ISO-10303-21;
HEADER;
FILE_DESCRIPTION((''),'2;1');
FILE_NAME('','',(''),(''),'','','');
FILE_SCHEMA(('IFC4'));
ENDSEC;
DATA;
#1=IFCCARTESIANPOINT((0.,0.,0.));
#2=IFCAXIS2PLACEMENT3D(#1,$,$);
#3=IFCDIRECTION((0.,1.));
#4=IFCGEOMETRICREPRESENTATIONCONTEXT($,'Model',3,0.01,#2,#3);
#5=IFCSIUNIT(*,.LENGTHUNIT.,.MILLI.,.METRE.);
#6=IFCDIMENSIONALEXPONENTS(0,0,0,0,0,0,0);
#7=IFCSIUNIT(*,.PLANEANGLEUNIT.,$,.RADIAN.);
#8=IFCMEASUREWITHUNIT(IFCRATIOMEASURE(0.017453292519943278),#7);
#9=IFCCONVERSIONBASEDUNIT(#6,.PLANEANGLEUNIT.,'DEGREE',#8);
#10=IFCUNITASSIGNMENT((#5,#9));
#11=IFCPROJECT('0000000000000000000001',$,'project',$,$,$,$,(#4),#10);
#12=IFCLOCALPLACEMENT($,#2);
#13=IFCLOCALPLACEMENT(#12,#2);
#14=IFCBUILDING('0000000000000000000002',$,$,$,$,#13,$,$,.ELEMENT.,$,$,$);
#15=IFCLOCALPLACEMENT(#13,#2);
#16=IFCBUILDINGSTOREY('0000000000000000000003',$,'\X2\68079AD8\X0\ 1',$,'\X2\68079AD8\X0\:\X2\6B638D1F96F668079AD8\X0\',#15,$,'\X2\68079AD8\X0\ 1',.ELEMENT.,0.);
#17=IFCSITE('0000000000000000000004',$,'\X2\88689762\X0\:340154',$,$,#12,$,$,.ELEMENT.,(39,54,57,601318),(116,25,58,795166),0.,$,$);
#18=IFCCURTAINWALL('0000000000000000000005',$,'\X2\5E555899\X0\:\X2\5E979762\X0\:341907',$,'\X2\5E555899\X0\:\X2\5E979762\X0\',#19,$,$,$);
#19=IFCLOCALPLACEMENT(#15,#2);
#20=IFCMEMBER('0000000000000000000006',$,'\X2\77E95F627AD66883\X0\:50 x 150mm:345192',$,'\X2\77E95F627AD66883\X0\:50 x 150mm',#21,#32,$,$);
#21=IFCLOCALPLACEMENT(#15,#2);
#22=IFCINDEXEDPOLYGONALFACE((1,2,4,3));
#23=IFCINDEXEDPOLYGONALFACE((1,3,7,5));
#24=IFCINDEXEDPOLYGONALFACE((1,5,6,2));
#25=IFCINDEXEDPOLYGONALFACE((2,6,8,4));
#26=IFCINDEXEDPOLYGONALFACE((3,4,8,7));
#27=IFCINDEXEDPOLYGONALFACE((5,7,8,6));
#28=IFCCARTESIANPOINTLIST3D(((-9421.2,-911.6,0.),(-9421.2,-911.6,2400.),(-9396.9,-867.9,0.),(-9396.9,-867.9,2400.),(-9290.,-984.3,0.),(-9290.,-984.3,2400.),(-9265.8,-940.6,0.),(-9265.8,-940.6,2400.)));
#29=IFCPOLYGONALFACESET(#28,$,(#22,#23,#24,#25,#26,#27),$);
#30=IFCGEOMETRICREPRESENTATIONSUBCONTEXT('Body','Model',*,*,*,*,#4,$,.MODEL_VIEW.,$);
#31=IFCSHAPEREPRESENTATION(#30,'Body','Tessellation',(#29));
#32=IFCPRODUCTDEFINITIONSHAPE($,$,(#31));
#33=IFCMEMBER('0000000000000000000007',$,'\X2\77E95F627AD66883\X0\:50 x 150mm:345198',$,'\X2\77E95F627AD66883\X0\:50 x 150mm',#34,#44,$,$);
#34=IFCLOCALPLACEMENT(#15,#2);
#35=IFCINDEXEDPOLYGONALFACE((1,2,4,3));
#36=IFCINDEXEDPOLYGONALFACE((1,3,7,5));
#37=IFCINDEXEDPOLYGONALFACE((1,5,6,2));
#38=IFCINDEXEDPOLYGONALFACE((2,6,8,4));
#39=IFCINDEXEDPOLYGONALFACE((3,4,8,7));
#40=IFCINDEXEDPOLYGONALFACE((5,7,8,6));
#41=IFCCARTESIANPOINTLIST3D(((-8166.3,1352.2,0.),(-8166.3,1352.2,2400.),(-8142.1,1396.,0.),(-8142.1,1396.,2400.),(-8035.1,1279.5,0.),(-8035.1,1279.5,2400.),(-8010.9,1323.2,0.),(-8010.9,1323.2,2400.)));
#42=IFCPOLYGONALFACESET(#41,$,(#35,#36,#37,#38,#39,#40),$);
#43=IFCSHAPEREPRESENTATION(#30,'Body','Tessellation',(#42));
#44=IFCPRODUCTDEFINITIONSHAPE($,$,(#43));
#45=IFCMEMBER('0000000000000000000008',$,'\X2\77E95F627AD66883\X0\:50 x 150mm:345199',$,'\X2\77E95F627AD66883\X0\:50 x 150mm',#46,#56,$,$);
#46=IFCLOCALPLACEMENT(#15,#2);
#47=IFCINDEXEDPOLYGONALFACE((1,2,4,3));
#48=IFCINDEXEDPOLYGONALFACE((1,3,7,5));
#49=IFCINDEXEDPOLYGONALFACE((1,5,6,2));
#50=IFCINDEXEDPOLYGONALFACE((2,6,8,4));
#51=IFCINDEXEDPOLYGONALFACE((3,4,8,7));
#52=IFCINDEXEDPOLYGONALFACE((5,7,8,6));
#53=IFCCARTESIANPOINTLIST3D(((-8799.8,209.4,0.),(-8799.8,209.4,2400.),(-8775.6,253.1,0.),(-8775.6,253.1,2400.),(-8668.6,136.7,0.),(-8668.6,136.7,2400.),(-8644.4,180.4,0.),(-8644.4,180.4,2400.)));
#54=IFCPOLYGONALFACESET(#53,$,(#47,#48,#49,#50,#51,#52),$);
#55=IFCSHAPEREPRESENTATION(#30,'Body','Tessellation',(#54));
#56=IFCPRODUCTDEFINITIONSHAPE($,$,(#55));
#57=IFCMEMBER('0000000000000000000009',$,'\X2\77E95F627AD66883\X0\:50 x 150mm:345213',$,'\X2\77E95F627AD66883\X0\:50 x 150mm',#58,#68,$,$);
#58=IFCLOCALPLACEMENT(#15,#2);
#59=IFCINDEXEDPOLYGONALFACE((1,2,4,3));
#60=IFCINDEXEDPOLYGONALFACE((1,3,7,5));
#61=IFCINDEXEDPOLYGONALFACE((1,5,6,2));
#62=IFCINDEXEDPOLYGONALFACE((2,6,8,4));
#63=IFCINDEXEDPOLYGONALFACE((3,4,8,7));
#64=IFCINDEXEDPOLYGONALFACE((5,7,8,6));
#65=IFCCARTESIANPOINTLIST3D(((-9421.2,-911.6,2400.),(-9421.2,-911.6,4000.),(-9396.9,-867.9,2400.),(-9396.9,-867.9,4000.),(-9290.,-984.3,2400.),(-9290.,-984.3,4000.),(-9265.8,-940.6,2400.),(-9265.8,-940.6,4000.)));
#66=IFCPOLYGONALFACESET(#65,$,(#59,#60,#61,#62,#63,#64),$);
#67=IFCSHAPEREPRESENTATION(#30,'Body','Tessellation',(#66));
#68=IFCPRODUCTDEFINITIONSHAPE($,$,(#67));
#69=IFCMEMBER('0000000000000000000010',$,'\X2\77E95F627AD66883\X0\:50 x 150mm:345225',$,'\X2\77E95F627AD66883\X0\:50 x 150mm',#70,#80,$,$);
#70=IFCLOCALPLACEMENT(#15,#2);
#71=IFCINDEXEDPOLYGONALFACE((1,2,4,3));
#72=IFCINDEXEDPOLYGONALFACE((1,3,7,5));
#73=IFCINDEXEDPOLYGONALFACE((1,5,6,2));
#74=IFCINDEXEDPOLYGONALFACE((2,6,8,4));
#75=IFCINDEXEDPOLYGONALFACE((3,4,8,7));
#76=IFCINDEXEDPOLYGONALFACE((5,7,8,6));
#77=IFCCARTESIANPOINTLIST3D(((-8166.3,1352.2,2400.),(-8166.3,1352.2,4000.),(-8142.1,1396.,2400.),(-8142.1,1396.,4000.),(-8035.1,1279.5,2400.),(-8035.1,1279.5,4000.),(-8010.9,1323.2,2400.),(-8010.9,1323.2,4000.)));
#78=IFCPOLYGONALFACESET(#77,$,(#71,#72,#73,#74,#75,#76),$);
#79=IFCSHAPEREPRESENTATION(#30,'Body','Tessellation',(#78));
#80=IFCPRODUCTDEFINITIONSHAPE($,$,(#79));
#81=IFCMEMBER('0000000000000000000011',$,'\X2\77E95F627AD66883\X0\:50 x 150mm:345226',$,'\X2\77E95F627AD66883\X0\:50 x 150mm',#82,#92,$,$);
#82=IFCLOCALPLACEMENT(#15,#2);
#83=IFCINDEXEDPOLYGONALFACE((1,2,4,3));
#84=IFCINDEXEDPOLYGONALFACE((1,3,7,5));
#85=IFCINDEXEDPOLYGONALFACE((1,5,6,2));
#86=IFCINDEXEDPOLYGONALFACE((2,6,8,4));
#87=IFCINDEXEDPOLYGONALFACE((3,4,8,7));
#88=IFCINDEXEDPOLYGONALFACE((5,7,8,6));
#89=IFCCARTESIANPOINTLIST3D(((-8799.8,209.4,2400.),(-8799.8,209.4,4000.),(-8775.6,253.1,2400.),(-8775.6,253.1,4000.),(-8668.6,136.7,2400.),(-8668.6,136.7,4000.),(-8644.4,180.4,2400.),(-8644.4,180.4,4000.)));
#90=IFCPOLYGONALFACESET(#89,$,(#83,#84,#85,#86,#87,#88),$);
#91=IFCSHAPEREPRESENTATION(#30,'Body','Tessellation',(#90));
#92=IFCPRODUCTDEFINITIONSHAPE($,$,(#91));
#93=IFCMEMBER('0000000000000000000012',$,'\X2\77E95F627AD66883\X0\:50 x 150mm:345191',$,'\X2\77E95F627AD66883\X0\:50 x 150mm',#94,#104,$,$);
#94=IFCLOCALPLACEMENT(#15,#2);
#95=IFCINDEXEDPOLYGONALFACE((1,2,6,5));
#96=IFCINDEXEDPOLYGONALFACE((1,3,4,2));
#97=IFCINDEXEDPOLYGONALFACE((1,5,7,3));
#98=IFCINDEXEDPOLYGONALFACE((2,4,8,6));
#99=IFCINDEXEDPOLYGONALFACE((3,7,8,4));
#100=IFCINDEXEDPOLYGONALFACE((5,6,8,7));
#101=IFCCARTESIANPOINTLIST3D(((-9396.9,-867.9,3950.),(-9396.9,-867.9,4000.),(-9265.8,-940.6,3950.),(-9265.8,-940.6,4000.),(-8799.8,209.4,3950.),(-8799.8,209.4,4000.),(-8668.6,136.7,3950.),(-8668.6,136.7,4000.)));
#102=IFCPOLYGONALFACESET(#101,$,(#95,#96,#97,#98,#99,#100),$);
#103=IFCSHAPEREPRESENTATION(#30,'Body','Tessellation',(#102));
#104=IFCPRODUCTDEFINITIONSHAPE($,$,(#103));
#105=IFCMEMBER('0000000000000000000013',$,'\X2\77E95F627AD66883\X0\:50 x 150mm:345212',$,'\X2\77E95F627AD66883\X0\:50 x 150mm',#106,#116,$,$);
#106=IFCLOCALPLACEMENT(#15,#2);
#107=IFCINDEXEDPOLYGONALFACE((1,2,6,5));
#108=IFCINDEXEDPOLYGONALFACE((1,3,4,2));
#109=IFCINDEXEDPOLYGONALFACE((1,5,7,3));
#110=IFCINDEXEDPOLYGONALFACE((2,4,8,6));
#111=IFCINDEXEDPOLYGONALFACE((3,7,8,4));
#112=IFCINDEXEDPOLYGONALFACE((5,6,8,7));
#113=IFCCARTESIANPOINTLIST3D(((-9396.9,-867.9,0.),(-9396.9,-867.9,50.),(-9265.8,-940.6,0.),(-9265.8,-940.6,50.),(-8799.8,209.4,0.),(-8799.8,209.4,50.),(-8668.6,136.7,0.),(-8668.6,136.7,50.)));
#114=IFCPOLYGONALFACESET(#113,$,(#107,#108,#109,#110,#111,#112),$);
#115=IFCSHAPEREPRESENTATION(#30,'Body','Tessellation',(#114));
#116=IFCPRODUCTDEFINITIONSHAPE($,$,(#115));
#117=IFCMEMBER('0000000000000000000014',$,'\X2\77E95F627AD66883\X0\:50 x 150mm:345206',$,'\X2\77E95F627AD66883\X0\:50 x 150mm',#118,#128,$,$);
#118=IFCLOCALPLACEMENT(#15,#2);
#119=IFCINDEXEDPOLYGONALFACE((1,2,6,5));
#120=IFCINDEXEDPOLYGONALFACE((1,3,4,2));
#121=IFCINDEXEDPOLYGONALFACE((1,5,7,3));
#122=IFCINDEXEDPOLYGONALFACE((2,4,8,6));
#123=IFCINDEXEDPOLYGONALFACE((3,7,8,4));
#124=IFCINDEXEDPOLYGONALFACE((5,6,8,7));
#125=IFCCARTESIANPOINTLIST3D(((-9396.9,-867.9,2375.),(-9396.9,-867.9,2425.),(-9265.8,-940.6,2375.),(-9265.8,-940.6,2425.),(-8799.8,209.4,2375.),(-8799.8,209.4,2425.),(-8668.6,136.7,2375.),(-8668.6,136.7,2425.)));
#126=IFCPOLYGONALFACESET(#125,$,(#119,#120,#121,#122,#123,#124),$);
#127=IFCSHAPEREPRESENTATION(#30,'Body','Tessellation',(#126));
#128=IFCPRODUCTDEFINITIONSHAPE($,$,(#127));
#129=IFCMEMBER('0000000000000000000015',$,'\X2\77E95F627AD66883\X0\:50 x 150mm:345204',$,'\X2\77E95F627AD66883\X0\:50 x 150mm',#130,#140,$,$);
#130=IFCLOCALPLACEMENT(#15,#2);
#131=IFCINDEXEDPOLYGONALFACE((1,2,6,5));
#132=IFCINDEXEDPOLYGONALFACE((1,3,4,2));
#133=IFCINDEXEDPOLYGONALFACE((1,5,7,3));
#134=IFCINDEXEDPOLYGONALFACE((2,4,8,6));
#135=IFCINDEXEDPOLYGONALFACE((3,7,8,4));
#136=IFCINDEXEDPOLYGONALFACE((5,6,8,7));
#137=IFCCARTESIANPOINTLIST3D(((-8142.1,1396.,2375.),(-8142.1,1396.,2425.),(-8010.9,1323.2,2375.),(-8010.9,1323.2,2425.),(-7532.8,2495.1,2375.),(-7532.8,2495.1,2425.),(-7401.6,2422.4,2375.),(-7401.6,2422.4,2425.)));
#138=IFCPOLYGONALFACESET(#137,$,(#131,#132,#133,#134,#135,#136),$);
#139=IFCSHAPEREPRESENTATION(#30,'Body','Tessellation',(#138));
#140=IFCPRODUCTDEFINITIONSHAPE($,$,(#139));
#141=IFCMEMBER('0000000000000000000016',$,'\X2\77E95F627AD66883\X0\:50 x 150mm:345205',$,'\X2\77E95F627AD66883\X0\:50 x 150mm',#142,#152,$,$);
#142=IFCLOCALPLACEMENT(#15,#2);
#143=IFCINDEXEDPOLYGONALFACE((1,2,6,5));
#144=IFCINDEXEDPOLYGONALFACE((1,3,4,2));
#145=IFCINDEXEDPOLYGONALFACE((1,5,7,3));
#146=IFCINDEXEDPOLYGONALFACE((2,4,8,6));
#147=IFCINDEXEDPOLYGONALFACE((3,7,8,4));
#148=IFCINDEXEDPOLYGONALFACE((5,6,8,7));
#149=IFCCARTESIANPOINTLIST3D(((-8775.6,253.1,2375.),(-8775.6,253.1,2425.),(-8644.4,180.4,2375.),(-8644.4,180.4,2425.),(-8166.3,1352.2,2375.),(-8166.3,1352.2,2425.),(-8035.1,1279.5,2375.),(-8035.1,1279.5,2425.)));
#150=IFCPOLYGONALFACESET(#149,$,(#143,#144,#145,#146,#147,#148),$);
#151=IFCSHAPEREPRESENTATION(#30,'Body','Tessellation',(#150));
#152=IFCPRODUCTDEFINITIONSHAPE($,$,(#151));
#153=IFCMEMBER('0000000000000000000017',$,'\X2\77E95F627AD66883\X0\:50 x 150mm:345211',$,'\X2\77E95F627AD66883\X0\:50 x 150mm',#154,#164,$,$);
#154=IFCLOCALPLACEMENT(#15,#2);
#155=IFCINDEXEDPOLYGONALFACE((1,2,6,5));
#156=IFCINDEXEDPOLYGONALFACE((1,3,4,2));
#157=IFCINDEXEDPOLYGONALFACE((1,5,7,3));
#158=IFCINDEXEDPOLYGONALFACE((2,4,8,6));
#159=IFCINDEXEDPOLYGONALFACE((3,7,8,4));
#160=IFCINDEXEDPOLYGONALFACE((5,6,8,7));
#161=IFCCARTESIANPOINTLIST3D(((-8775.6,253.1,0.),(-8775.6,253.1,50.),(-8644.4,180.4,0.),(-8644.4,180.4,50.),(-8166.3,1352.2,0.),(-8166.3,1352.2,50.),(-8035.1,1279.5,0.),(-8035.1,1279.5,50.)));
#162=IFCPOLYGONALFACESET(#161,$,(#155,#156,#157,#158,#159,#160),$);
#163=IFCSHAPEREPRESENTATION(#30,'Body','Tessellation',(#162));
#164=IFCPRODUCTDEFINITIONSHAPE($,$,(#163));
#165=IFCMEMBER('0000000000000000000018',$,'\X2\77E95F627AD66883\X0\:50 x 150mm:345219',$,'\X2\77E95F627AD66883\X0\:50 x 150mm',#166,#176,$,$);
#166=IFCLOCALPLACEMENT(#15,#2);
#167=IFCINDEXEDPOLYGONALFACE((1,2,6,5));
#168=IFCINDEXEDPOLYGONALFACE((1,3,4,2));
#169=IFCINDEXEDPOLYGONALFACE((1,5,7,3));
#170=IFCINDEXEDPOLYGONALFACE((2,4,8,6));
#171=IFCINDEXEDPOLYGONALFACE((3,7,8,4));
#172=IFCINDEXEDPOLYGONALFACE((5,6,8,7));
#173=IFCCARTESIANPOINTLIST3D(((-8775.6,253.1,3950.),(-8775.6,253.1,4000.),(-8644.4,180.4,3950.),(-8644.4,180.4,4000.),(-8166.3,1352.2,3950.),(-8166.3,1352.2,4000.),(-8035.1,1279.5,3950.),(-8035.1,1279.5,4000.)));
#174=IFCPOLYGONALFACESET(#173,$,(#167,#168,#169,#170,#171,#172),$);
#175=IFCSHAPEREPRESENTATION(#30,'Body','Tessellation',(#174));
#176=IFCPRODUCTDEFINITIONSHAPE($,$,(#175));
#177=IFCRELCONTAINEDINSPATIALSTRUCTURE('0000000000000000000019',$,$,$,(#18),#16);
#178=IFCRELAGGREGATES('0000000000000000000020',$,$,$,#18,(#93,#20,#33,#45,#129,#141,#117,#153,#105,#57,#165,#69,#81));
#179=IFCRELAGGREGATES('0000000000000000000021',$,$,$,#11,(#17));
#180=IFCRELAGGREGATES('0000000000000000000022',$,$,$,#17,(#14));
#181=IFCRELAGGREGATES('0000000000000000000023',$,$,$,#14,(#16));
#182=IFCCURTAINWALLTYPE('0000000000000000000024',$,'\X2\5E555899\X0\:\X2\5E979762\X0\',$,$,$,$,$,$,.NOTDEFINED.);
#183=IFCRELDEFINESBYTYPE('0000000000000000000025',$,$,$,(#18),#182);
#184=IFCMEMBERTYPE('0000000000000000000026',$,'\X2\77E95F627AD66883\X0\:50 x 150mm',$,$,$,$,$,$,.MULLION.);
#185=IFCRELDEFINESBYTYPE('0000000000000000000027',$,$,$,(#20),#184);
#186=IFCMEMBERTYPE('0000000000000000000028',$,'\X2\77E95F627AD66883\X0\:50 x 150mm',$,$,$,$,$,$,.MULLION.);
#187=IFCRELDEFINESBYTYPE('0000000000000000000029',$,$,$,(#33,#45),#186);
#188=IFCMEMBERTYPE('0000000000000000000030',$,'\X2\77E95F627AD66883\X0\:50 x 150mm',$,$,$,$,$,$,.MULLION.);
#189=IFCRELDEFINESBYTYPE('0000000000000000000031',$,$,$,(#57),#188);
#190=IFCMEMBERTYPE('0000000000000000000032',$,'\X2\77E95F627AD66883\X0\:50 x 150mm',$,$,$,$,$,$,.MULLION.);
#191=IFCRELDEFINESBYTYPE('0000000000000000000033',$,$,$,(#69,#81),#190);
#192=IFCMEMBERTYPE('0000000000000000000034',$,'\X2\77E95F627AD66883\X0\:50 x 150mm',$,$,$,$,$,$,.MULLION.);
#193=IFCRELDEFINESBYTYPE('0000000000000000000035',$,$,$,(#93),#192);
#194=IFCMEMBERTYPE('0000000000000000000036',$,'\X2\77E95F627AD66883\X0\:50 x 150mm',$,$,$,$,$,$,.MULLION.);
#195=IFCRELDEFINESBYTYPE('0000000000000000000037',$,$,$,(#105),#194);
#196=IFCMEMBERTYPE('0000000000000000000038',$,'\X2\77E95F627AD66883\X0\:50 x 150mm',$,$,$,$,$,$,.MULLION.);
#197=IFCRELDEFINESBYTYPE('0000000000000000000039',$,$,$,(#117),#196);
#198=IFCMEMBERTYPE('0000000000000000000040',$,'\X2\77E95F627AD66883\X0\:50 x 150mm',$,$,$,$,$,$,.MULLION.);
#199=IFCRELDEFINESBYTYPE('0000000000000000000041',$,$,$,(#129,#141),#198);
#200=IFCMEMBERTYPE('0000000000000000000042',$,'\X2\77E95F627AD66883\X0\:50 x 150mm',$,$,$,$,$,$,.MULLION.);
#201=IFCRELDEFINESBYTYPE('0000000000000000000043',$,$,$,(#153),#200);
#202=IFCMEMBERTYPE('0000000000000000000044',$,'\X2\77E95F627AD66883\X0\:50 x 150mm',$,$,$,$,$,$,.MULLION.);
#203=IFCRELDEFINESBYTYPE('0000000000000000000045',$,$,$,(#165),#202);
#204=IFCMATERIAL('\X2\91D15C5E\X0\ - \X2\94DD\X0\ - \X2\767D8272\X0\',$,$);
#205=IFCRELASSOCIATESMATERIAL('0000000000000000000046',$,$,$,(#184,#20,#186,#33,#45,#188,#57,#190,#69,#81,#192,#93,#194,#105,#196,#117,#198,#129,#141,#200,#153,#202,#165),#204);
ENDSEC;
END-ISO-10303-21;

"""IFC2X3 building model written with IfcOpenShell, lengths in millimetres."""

from ifc_helpers import new_model, entity, si_unit, converted_unit, direction, frame, origin, origin_2d_with_axis, place, context, subcontext, project, spatial, rectangle, extrude, source, transform, mapped, material, type_object, type_shapes, element, aggregate, save


model = new_model("IFC2X3")

# Units and contexts
model_context = context("Model", 3, precision=0.01, world=origin(), true_north=direction((0.0, 1.0)))
body_context = subcontext(model_context, "Body", "Model", "MODEL_VIEW")
ifc_project = project(units=[si_unit("LENGTHUNIT", "METRE", prefix="MILLI"), converted_unit("PLANEANGLEUNIT", "DEGREE", entity("IfcRatioMeasure", 0.017453292519943278), si_unit("PLANEANGLEUNIT", "RADIAN"), dimensions=[0, 0, 0, 0, 0, 0, 0])], contexts=[model_context])

# Site, building, storey
site_placement = place(None, origin())
site = spatial("IfcSite", under=ifc_project, at=site_placement, Name="表面:340154", CompositionType="ELEMENT", RefLatitude=(39, 54, 57, 601318), RefLongitude=(116, 25, 58, 795166), RefElevation=0.0)
building_placement = place(site_placement, origin())
building = spatial("IfcBuilding", under=site, at=building_placement, CompositionType="ELEMENT")
storey_placement = place(building_placement, origin())
storey = spatial("IfcBuildingStorey", under=building, at=storey_placement, Name="标高 1", ObjectType="标高:正负零标高", LongName="标高 1", CompositionType="ELEMENT", Elevation=0.0)

# Curtain wall, members
curtain_wall_type = type_object("IfcCurtainWallType", Name="幕墙:店面", PredefinedType="NOTDEFINED")
curtain_wall_1_placement = place(storey_placement, origin())
curtain_wall_1 = element("IfcCurtainWall", 1, at=curtain_wall_1_placement, inside=storey, type_object=curtain_wall_type, Name="幕墙:店面:341907", ObjectType="幕墙:店面")
ifc_material_1 = material(Name="金属 - 铝 - 白色")
member_type_1 = type_object("IfcMemberType", Name="矩形竖梃:50 x 150mm", PredefinedType="MULLION", material=ifc_material_1)
shared_shape_1 = source(origin(), body_context, "Body", "SweptSolid", [
    extrude(rectangle(XDim=150.0, YDim=50.0, at=origin_2d_with_axis()), frame((-25.0, 0.0, -2400.0), z_axis=(0.0, 0.0, 1.0), x_axis=(0.0, -1.0, 0.0)), (0.0, 0.0, 1.0), 2400.0),
])
type_shapes(member_type_1, [shared_shape_1])
member_1_placement = place(curtain_wall_1_placement, frame((-9355.6, -948.0, 0.0), z_axis=(0.0, 0.0, -1.0), x_axis=(-0.48481, -0.87462, 0.0)))
member_1 = element("IfcMember", 2, at=member_1_placement, type_object=member_type_1, material=ifc_material_1, Name="矩形竖梃:50 x 150mm:345192", ObjectType="矩形竖梃:50 x 150mm", context=body_context, shape_type="MappedRepresentation", body=[
    mapped(shared_shape_1, transform((0.0, 0.0, 0.0), scale=1.0)),
])
member_type_2 = type_object("IfcMemberType", Name="矩形竖梃:50 x 150mm", PredefinedType="MULLION", material=ifc_material_1)
shared_shape_2 = source(origin(), body_context, "Body", "SweptSolid", [
    extrude(rectangle(XDim=150.0, YDim=50.0, at=origin_2d_with_axis()), frame((0.0, 0.0, -2400.0), z_axis=(0.0, 0.0, 1.0), x_axis=(0.0, -1.0, 0.0)), (0.0, 0.0, 1.0), 2400.0),
])
type_shapes(member_type_2, [shared_shape_2])
member_2_placement = place(curtain_wall_1_placement, frame((-8088.6, 1337.7, 0.0), z_axis=(0.0, 0.0, -1.0), x_axis=(-0.48481, -0.87462, 0.0)))
member_2 = element("IfcMember", 3, at=member_2_placement, type_object=member_type_2, material=ifc_material_1, Name="矩形竖梃:50 x 150mm:345198", ObjectType="矩形竖梃:50 x 150mm", context=body_context, shape_type="MappedRepresentation", body=[
    mapped(shared_shape_2, transform((0.0, 0.0, 0.0), scale=1.0)),
])
member_3_placement = place(curtain_wall_1_placement, frame((-8722.1, 194.9, 0.0), z_axis=(0.0, 0.0, -1.0), x_axis=(-0.48481, -0.87462, 0.0)))
member_3 = element("IfcMember", 4, at=member_3_placement, type_object=member_type_2, material=ifc_material_1, Name="矩形竖梃:50 x 150mm:345199", ObjectType="矩形竖梃:50 x 150mm", context=body_context, shape_type="MappedRepresentation", body=[
    mapped(shared_shape_2, transform((0.0, 0.0, 0.0), scale=1.0)),
])
member_type_3 = type_object("IfcMemberType", Name="矩形竖梃:50 x 150mm", PredefinedType="MULLION", material=ifc_material_1)
shared_shape_3 = source(origin(), body_context, "Body", "SweptSolid", [
    extrude(rectangle(XDim=150.0, YDim=50.0, at=origin_2d_with_axis()), frame((-25.0, 0.0, -1600.0), z_axis=(0.0, 0.0, 1.0), x_axis=(0.0, -1.0, 0.0)), (0.0, 0.0, 1.0), 1600.0),
])
type_shapes(member_type_3, [shared_shape_3])
member_4_placement = place(curtain_wall_1_placement, frame((-9355.6, -948.0, 2400.0), z_axis=(0.0, 0.0, -1.0), x_axis=(-0.48481, -0.87462, 0.0)))
member_4 = element("IfcMember", 5, at=member_4_placement, type_object=member_type_3, material=ifc_material_1, Name="矩形竖梃:50 x 150mm:345213", ObjectType="矩形竖梃:50 x 150mm", context=body_context, shape_type="MappedRepresentation", body=[
    mapped(shared_shape_3, transform((0.0, 0.0, 0.0), scale=1.0)),
])
member_type_4 = type_object("IfcMemberType", Name="矩形竖梃:50 x 150mm", PredefinedType="MULLION", material=ifc_material_1)
shared_shape_4 = source(origin(), body_context, "Body", "SweptSolid", [
    extrude(rectangle(XDim=150.0, YDim=50.0, at=origin_2d_with_axis()), frame((0.0, 0.0, -1600.0), z_axis=(0.0, 0.0, 1.0), x_axis=(0.0, -1.0, 0.0)), (0.0, 0.0, 1.0), 1600.0),
])
type_shapes(member_type_4, [shared_shape_4])
member_5_placement = place(curtain_wall_1_placement, frame((-8088.6, 1337.7, 2400.0), z_axis=(0.0, 0.0, -1.0), x_axis=(-0.48481, -0.87462, 0.0)))
member_5 = element("IfcMember", 6, at=member_5_placement, type_object=member_type_4, material=ifc_material_1, Name="矩形竖梃:50 x 150mm:345225", ObjectType="矩形竖梃:50 x 150mm", context=body_context, shape_type="MappedRepresentation", body=[
    mapped(shared_shape_4, transform((0.0, 0.0, 0.0), scale=1.0)),
])
member_6_placement = place(curtain_wall_1_placement, frame((-8722.1, 194.9, 2400.0), z_axis=(0.0, 0.0, -1.0), x_axis=(-0.48481, -0.87462, 0.0)))
member_6 = element("IfcMember", 7, at=member_6_placement, type_object=member_type_4, material=ifc_material_1, Name="矩形竖梃:50 x 150mm:345226", ObjectType="矩形竖梃:50 x 150mm", context=body_context, shape_type="MappedRepresentation", body=[
    mapped(shared_shape_4, transform((0.0, 0.0, 0.0), scale=1.0)),
])
member_type_5 = type_object("IfcMemberType", Name="矩形竖梃:50 x 150mm", PredefinedType="MULLION", material=ifc_material_1)
shared_shape_5 = source(origin(), body_context, "Body", "SweptSolid", [
    extrude(rectangle(XDim=150.0, YDim=50.0, at=origin_2d_with_axis()), frame((-25.0, 0.0, -1231.7), z_axis=(0.0, 0.0, 1.0), x_axis=(0.0, -1.0, 0.0)), (0.0, 0.0, 1.0), 1231.7),
])
type_shapes(member_type_5, [shared_shape_5])
member_7_placement = place(curtain_wall_1_placement, frame((-9331.3, -904.2, 4000.0), z_axis=(-0.48481, -0.87462, 0.0), x_axis=(0.0, 0.0, 1.0)))
member_7 = element("IfcMember", 8, at=member_7_placement, type_object=member_type_5, material=ifc_material_1, Name="矩形竖梃:50 x 150mm:345191", ObjectType="矩形竖梃:50 x 150mm", context=body_context, shape_type="MappedRepresentation", body=[
    mapped(shared_shape_5, transform((0.0, 0.0, 0.0), scale=1.0)),
])
member_type_6 = type_object("IfcMemberType", Name="矩形竖梃:50 x 150mm", PredefinedType="MULLION", material=ifc_material_1)
shared_shape_6 = source(origin(), body_context, "Body", "SweptSolid", [
    extrude(rectangle(XDim=150.0, YDim=50.0, at=origin_2d_with_axis()), frame((-25.0, 0.0, -1231.7), z_axis=(0.0, 0.0, 1.0), x_axis=(0.0, -1.0, 0.0)), (0.0, 0.0, 1.0), 1231.7),
])
type_shapes(member_type_6, [shared_shape_6])
member_8_placement = place(curtain_wall_1_placement, frame((-8734.2, 173.0, 0.0), z_axis=(0.48481, 0.87462, 0.0), x_axis=(0.0, 0.0, -1.0)))
member_8 = element("IfcMember", 9, at=member_8_placement, type_object=member_type_6, material=ifc_material_1, Name="矩形竖梃:50 x 150mm:345212", ObjectType="矩形竖梃:50 x 150mm", context=body_context, shape_type="MappedRepresentation", body=[
    mapped(shared_shape_6, transform((0.0, 0.0, 0.0), scale=1.0)),
])
member_type_7 = type_object("IfcMemberType", Name="矩形竖梃:50 x 150mm", PredefinedType="MULLION", material=ifc_material_1)
shared_shape_7 = source(origin(), body_context, "Body", "SweptSolid", [
    extrude(rectangle(XDim=150.0, YDim=50.0, at=origin_2d_with_axis()), frame((0.0, 0.0, -1231.7), z_axis=(0.0, 0.0, 1.0), x_axis=(0.0, -1.0, 0.0)), (0.0, 0.0, 1.0), 1231.7),
])
type_shapes(member_type_7, [shared_shape_7])
member_9_placement = place(curtain_wall_1_placement, frame((-9331.3, -904.2, 2400.0), z_axis=(-0.48481, -0.87462, 0.0), x_axis=(0.0, 0.0, 1.0)))
member_9 = element("IfcMember", 10, at=member_9_placement, type_object=member_type_7, material=ifc_material_1, Name="矩形竖梃:50 x 150mm:345206", ObjectType="矩形竖梃:50 x 150mm", context=body_context, shape_type="MappedRepresentation", body=[
    mapped(shared_shape_7, transform((0.0, 0.0, 0.0), scale=1.0)),
])
member_type_8 = type_object("IfcMemberType", Name="矩形竖梃:50 x 150mm", PredefinedType="MULLION", material=ifc_material_1)
shared_shape_8 = source(origin(), body_context, "Body", "SweptSolid", [
    extrude(rectangle(XDim=150.0, YDim=50.0, at=origin_2d_with_axis()), frame((0.0, 0.0, -1256.7), z_axis=(0.0, 0.0, 1.0), x_axis=(0.0, -1.0, 0.0)), (0.0, 0.0, 1.0), 1256.7),
])
type_shapes(member_type_8, [shared_shape_8])
member_10_placement = place(curtain_wall_1_placement, frame((-8076.5, 1359.6, 2400.0), z_axis=(-0.48481, -0.87462, 0.0), x_axis=(0.0, 0.0, 1.0)))
member_10 = element("IfcMember", 11, at=member_10_placement, type_object=member_type_8, material=ifc_material_1, Name="矩形竖梃:50 x 150mm:345204", ObjectType="矩形竖梃:50 x 150mm", context=body_context, shape_type="MappedRepresentation", body=[
    mapped(shared_shape_8, transform((0.0, 0.0, 0.0), scale=1.0)),
])
member_11_placement = place(curtain_wall_1_placement, frame((-8710.0, 216.7, 2400.0), z_axis=(-0.48481, -0.87462, 0.0), x_axis=(0.0, 0.0, 1.0)))
member_11 = element("IfcMember", 12, at=member_11_placement, type_object=member_type_8, material=ifc_material_1, Name="矩形竖梃:50 x 150mm:345205", ObjectType="矩形竖梃:50 x 150mm", context=body_context, shape_type="MappedRepresentation", body=[
    mapped(shared_shape_8, transform((0.0, 0.0, 0.0), scale=1.0)),
])
member_type_9 = type_object("IfcMemberType", Name="矩形竖梃:50 x 150mm", PredefinedType="MULLION", material=ifc_material_1)
shared_shape_9 = source(origin(), body_context, "Body", "SweptSolid", [
    extrude(rectangle(XDim=150.0, YDim=50.0, at=origin_2d_with_axis()), frame((-25.0, 0.0, -1256.7), z_axis=(0.0, 0.0, 1.0), x_axis=(0.0, -1.0, 0.0)), (0.0, 0.0, 1.0), 1256.7),
])
type_shapes(member_type_9, [shared_shape_9])
member_12_placement = place(curtain_wall_1_placement, frame((-8100.7, 1315.9, 0.0), z_axis=(0.48481, 0.87462, 0.0), x_axis=(0.0, 0.0, -1.0)))
member_12 = element("IfcMember", 13, at=member_12_placement, type_object=member_type_9, material=ifc_material_1, Name="矩形竖梃:50 x 150mm:345211", ObjectType="矩形竖梃:50 x 150mm", context=body_context, shape_type="MappedRepresentation", body=[
    mapped(shared_shape_9, transform((0.0, 0.0, 0.0), scale=1.0)),
])
member_type_10 = type_object("IfcMemberType", Name="矩形竖梃:50 x 150mm", PredefinedType="MULLION", material=ifc_material_1)
shared_shape_10 = source(origin(), body_context, "Body", "SweptSolid", [
    extrude(rectangle(XDim=150.0, YDim=50.0, at=origin_2d_with_axis()), frame((-25.0, 0.0, -1256.7), z_axis=(0.0, 0.0, 1.0), x_axis=(0.0, -1.0, 0.0)), (0.0, 0.0, 1.0), 1256.7),
])
type_shapes(member_type_10, [shared_shape_10])
member_13_placement = place(curtain_wall_1_placement, frame((-8710.0, 216.7, 4000.0), z_axis=(-0.48481, -0.87462, 0.0), x_axis=(0.0, 0.0, 1.0)))
member_13 = element("IfcMember", 14, at=member_13_placement, type_object=member_type_10, material=ifc_material_1, Name="矩形竖梃:50 x 150mm:345219", ObjectType="矩形竖梃:50 x 150mm", context=body_context, shape_type="MappedRepresentation", body=[
    mapped(shared_shape_10, transform((0.0, 0.0, 0.0), scale=1.0)),
])
aggregate(curtain_wall_1, [member_7, member_1, member_2, member_3, member_10, member_11, member_9, member_12, member_8, member_4, member_13, member_5, member_6])

save(model, "model.ifc")
